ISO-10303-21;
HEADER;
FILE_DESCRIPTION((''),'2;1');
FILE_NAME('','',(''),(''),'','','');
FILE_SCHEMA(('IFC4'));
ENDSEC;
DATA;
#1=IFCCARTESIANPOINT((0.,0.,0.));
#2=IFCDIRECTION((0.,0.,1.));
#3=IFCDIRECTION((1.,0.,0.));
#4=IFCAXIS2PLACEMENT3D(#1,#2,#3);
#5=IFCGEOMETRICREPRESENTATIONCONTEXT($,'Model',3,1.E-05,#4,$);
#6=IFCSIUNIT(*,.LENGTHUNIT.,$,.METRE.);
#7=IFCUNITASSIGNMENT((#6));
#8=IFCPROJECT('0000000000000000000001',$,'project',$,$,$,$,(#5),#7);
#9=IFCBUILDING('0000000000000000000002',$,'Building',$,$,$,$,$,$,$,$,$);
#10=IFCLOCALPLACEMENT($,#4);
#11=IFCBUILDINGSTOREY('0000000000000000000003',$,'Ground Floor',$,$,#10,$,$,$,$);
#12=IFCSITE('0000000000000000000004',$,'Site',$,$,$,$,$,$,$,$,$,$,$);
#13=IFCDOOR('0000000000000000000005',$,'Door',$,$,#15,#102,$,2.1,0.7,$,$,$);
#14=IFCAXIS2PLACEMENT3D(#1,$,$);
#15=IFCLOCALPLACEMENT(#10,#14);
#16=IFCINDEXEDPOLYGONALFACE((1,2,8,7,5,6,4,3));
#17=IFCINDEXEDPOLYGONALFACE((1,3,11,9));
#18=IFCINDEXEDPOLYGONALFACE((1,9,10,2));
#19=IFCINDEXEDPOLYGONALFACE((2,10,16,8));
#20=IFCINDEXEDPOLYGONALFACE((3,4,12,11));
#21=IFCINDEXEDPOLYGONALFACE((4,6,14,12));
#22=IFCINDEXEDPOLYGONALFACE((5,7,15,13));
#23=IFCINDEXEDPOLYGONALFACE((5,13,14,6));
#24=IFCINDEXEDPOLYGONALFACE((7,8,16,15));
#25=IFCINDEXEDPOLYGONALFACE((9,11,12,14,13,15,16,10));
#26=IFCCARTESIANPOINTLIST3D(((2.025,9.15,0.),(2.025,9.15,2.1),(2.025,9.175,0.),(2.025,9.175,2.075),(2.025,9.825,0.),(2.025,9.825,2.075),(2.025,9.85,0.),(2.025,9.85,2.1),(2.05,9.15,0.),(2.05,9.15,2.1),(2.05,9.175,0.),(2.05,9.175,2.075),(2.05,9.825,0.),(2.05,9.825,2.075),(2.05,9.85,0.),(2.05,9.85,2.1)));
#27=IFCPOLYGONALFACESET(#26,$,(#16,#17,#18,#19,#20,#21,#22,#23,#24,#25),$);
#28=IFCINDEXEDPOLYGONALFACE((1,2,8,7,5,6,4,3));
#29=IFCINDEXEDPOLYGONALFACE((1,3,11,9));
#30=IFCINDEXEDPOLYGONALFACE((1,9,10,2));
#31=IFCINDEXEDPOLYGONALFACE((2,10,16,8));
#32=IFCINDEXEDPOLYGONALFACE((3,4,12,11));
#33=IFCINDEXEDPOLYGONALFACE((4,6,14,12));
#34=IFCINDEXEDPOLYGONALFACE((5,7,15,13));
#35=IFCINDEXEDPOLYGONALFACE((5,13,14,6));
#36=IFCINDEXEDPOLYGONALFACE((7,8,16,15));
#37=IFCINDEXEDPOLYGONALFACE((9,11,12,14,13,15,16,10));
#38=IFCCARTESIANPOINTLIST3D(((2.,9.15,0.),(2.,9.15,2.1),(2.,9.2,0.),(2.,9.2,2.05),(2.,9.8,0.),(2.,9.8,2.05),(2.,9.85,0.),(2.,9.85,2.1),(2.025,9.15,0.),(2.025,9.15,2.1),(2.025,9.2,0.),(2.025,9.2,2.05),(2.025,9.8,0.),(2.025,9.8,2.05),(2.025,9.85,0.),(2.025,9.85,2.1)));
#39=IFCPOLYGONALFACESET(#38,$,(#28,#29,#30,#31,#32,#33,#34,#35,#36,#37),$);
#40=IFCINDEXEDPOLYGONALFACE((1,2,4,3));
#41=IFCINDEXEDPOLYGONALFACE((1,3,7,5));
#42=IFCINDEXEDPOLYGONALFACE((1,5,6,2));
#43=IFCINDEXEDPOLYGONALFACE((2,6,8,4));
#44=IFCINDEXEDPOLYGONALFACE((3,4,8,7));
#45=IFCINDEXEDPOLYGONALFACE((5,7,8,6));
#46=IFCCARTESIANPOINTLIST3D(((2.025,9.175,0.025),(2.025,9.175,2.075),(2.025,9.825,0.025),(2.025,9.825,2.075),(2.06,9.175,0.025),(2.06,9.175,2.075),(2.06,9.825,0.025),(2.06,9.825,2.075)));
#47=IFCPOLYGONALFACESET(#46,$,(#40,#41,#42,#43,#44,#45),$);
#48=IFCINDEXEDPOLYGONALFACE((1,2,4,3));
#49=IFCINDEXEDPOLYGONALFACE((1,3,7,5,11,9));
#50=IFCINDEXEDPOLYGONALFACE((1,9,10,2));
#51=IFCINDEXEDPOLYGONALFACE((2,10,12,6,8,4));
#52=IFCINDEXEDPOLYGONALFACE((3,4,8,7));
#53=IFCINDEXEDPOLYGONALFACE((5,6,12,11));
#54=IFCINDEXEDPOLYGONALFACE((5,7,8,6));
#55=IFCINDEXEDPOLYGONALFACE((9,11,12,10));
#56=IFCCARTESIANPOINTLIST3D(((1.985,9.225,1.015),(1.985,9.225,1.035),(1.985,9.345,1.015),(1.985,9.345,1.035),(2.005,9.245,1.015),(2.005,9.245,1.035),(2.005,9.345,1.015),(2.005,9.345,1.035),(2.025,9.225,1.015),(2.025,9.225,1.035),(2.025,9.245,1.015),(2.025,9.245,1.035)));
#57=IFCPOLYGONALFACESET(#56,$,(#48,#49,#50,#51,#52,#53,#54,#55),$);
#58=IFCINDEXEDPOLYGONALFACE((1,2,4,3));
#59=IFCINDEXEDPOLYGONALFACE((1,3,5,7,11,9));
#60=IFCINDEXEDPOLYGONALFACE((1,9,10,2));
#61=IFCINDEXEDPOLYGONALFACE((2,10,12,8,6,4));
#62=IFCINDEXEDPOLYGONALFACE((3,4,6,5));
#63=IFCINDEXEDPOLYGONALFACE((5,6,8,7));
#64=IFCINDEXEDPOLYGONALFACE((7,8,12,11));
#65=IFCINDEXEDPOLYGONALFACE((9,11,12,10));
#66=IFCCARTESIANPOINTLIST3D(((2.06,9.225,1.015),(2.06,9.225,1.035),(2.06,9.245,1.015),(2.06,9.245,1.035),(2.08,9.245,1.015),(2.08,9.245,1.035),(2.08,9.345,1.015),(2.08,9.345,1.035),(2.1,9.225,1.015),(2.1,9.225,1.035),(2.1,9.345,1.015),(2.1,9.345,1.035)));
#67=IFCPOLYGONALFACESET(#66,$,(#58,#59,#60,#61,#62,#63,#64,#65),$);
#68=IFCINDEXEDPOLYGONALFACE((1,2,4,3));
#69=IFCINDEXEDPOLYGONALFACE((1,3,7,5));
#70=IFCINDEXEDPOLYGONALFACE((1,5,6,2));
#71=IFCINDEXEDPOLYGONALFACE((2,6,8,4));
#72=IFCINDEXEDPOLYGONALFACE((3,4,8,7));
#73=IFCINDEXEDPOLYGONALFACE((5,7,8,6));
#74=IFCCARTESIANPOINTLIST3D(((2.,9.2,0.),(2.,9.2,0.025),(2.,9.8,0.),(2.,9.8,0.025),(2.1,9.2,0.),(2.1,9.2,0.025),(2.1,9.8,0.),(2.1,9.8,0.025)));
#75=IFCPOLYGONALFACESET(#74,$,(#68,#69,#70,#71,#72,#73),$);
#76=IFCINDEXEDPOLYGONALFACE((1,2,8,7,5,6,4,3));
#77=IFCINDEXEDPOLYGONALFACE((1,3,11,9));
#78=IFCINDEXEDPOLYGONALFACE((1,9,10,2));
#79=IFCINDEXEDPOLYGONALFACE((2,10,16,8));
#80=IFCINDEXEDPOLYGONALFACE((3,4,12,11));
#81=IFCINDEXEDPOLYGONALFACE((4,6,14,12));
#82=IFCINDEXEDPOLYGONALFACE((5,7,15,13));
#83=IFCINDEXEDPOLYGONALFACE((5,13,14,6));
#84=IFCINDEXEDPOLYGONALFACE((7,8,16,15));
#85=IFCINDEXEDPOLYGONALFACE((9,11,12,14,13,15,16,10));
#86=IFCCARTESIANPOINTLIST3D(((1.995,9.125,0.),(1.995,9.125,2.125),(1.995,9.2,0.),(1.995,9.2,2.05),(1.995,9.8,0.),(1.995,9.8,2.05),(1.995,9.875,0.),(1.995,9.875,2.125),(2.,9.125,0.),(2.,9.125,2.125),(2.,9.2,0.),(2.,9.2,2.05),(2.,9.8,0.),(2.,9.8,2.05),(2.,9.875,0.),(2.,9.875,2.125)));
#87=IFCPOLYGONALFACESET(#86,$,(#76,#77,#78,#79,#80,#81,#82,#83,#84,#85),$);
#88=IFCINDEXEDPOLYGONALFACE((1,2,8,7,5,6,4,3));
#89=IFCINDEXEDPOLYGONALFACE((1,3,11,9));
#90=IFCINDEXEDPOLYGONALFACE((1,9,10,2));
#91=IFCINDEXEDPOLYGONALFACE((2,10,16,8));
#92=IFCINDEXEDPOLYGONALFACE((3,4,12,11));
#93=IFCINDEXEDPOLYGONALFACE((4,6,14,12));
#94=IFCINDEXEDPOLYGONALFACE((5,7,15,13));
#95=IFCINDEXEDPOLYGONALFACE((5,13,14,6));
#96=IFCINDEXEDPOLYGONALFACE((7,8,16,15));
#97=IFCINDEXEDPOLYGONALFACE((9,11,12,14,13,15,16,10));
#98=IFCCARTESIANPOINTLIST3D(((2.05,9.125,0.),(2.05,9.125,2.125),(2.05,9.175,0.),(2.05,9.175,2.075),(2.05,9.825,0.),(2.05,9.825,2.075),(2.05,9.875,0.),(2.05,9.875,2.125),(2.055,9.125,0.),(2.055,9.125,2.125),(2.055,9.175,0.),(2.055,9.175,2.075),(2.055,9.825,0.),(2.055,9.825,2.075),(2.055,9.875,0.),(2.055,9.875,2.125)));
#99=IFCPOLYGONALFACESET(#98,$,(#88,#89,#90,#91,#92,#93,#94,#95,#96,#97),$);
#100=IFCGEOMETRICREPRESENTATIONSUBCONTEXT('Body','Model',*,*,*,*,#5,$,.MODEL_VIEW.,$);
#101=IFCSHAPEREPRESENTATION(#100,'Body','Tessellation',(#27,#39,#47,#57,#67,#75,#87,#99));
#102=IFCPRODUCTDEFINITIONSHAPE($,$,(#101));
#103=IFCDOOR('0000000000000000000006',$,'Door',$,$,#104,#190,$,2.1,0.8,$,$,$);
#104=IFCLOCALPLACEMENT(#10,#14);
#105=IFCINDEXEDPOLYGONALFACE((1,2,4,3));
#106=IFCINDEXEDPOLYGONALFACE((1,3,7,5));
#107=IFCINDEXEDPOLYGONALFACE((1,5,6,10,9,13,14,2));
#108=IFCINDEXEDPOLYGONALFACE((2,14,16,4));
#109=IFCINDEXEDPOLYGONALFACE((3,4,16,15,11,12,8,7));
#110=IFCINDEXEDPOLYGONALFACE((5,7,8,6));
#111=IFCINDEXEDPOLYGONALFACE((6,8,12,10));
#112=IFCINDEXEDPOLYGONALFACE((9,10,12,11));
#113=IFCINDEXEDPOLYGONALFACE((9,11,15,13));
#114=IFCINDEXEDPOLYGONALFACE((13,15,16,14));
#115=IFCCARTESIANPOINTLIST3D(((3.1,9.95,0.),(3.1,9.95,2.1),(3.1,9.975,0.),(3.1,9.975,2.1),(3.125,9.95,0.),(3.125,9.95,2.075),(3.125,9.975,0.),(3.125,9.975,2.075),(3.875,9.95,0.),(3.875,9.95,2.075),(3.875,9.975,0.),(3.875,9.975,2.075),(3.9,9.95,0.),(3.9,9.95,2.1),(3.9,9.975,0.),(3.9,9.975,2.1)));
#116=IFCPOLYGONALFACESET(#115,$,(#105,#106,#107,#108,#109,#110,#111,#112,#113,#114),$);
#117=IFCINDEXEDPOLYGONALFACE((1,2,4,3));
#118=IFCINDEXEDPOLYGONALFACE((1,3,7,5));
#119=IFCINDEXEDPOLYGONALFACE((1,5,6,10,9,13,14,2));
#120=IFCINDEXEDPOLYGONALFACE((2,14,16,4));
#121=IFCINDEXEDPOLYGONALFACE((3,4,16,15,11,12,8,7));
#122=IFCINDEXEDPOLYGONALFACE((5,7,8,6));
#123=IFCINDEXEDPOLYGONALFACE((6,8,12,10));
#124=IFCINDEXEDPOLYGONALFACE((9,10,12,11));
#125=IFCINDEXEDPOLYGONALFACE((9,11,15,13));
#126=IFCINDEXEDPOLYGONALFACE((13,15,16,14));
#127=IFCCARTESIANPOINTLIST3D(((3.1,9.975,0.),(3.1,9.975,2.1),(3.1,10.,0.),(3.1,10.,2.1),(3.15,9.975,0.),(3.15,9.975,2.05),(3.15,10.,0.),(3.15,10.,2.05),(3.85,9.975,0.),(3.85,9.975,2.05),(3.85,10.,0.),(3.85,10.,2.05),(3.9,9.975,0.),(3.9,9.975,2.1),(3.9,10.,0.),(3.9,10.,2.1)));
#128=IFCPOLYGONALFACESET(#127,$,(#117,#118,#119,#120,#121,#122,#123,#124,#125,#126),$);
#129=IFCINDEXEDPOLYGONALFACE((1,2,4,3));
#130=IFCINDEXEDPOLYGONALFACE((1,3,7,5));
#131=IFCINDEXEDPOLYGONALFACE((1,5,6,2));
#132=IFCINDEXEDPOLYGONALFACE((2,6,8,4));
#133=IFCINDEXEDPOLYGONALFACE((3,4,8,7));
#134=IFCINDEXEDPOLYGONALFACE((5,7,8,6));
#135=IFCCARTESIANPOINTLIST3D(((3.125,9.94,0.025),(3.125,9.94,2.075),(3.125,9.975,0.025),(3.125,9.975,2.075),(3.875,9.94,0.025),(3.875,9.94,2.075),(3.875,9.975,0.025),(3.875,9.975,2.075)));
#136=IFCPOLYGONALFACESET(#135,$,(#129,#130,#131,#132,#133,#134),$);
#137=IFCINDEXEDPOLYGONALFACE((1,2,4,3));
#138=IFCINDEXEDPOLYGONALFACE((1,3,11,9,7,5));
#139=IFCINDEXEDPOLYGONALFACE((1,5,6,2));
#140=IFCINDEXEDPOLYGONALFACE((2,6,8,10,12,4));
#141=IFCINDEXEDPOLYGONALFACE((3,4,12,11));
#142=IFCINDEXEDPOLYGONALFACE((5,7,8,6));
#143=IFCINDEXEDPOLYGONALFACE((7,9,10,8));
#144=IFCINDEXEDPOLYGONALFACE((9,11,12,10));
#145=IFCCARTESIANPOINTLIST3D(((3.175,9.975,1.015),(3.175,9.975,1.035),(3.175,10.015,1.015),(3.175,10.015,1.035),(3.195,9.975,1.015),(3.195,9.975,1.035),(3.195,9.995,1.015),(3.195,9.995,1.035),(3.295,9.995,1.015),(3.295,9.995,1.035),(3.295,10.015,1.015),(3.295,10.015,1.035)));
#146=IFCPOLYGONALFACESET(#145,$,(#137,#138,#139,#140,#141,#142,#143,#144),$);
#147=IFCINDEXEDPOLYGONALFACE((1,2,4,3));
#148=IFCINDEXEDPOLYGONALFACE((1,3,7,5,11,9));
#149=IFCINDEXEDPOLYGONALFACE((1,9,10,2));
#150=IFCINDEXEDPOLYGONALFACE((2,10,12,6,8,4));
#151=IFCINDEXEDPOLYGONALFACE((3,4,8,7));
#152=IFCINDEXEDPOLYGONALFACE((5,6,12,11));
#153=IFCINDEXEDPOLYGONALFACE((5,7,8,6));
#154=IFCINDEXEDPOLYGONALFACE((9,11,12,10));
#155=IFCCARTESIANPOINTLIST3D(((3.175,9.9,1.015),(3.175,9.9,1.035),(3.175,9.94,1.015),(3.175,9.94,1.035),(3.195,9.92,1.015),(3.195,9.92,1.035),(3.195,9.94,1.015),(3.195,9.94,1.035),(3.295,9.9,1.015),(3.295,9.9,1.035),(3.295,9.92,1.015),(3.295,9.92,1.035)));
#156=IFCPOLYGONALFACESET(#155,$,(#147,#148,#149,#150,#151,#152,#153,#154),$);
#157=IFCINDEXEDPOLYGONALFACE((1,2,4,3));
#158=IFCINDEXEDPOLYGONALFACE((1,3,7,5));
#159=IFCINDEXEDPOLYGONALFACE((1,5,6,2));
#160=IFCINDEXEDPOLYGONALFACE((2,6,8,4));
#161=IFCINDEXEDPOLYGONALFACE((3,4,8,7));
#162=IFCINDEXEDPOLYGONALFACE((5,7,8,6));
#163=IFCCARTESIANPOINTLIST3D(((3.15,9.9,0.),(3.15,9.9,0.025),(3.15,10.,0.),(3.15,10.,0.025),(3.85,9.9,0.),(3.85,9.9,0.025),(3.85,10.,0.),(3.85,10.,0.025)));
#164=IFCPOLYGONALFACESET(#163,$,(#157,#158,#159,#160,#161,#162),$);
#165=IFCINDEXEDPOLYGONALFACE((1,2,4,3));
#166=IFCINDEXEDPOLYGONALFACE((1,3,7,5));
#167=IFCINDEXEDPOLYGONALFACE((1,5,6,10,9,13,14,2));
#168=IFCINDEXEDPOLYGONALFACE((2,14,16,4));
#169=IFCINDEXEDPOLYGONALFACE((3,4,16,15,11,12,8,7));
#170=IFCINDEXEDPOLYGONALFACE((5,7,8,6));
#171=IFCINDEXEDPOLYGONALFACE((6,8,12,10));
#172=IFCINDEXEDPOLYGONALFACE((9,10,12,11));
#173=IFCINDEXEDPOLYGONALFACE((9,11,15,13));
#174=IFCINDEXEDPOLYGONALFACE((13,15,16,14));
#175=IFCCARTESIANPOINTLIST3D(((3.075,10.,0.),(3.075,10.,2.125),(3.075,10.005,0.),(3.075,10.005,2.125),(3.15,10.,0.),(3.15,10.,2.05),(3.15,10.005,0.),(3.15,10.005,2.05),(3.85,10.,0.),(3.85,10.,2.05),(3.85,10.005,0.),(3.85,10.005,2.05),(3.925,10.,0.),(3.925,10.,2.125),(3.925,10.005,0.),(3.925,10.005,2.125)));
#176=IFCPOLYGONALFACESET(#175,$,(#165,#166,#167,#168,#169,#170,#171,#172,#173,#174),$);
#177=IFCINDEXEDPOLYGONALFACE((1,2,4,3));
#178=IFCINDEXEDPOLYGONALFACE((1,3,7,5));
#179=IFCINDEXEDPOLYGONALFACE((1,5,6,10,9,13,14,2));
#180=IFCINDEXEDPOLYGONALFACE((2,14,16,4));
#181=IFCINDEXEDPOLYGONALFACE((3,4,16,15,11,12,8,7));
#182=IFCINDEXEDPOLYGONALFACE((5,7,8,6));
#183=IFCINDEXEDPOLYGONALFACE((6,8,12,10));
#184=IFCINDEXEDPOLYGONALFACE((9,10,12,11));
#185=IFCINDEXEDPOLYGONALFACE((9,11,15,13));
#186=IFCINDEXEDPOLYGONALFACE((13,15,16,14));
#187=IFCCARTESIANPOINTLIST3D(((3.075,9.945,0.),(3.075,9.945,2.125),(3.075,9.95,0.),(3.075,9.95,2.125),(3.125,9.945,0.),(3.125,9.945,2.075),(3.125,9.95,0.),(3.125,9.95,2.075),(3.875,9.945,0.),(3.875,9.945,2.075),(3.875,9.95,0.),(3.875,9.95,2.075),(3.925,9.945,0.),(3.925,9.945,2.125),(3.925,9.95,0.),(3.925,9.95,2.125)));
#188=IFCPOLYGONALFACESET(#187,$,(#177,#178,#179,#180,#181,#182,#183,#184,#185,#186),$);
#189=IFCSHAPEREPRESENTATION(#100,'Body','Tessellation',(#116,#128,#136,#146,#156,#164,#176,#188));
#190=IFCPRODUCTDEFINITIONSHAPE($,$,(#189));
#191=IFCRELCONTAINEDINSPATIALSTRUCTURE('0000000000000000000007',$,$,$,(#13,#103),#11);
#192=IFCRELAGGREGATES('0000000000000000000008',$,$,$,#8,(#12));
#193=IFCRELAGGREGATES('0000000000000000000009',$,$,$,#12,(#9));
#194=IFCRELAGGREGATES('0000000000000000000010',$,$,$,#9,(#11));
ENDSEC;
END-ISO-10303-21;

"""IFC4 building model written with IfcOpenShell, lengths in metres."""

from ifc_helpers import new_model, si_unit, frame, origin_with_axes, place, context, subcontext, project, spatial, line, indexed_curve, outline, extrude, element, save


model = new_model("IFC4")

# Units and contexts
model_context = context("Model", 3, precision=1e-05, world=origin_with_axes())
body_context = subcontext(model_context, "Body", "Model", "MODEL_VIEW")
ifc_project = project(units=[si_unit("LENGTHUNIT", "METRE")], contexts=[model_context])

# Site, building, storey
site = spatial("IfcSite", under=ifc_project, Name="Site")
building = spatial("IfcBuilding", under=site, Name="Building")
storey_placement = place(None, origin_with_axes())
storey = spatial("IfcBuildingStorey", under=building, at=storey_placement, Name="Ground Floor")

# Doors
door_1_placement = place(storey_placement, frame((2.0, 9.85, 0.0), z_axis=(0.0, 0.0, 1.0), x_axis=(0.0, -1.0, 0.0)))
element("IfcDoor", 1, at=door_1_placement, inside=storey, Name="Door", OverallHeight=2.1, OverallWidth=0.7, context=body_context, shape_type="SweptSolid", body=[
    extrude(outline(indexed_curve([(0.0, 0.0), (0.0, 2.1), (0.7, 2.1), (0.7, 0.0), (0.675, 0.0), (0.675, 2.075), (0.025, 2.075), (0.025, 0.0)], segments=[line(1, 2, 3, 4, 5, 6, 7, 8, 1)])), frame((0.0, 0.025, 0.0), z_axis=(0.0, -1.0, 0.0), x_axis=(1.0, 0.0, 0.0)), (0.0, 0.0, -1.0), 0.025),
    extrude(outline(indexed_curve([(0.0, 0.0), (0.0, 2.1), (0.7, 2.1), (0.7, 0.0), (0.65, 0.0), (0.65, 2.05), (0.05, 2.05), (0.05, 0.0)], segments=[line(1, 2, 3, 4, 5, 6, 7, 8, 1)])), frame((0.0, 0.0, 0.0), z_axis=(0.0, -1.0, 0.0), x_axis=(1.0, 0.0, 0.0)), (0.0, 0.0, -1.0), 0.025),
    extrude(outline(indexed_curve([(0.0, 0.0), (0.65, 0.0), (0.65, 0.035), (0.0, 0.035)], segments=[line(1, 2, 3, 4, 1)])), frame((0.025, 0.025, 0.025), z_axis=(0.0, 0.0, 1.0), x_axis=(1.0, 0.0, 0.0)), (0.0, 0.0, 1.0), 2.05),
    extrude(outline(indexed_curve([(0.0, 0.0), (0.0, -0.04), (-0.12, -0.04), (-0.12, -0.02), (-0.02, -0.02), (-0.02, 0.0)], segments=[line(1, 2, 3, 4, 5, 6, 1)])), frame((0.625, 0.025, 1.015), z_axis=(0.0, 0.0, 1.0), x_axis=(1.0, 0.0, 0.0)), (0.0, 0.0, 1.0), 0.02),
    extrude(outline(indexed_curve([(0.0, 0.0), (0.0, 0.04), (-0.12, 0.04), (-0.12, 0.02), (-0.02, 0.02), (-0.02, 0.0)], segments=[line(1, 2, 3, 4, 5, 6, 1)])), frame((0.625, 0.06, 1.015), z_axis=(0.0, 0.0, 1.0), x_axis=(1.0, 0.0, 0.0)), (0.0, 0.0, 1.0), 0.02),
    extrude(outline(indexed_curve([(0.0, 0.0), (0.6, 0.0), (0.6, 0.1), (0.0, 0.1)], segments=[line(1, 2, 3, 4, 1)])), frame((0.05, 0.0, 0.0), z_axis=(0.0, 0.0, 1.0), x_axis=(1.0, 0.0, 0.0)), (0.0, 0.0, 1.0), 0.025),
    extrude(outline(indexed_curve([(0.0, 0.0), (0.0, 2.125), (0.75, 2.125), (0.75, 0.0), (0.675, 0.0), (0.675, 2.05), (0.075, 2.05), (0.075, 0.0)], segments=[line(1, 2, 3, 4, 5, 6, 7, 8, 1)])), frame((-0.025, -0.005, 0.0), z_axis=(0.0, -1.0, 0.0), x_axis=(1.0, 0.0, 0.0)), (0.0, 0.0, -1.0), 0.005),
    extrude(outline(indexed_curve([(0.0, 0.0), (0.0, 2.125), (0.75, 2.125), (0.75, 0.0), (0.7, 0.0), (0.7, 2.075), (0.05, 2.075), (0.05, 0.0)], segments=[line(1, 2, 3, 4, 5, 6, 7, 8, 1)])), frame((-0.025, 0.05, 0.0), z_axis=(0.0, -1.0, 0.0), x_axis=(1.0, 0.0, 0.0)), (0.0, 0.0, -1.0), 0.005),
])
door_2_placement = place(storey_placement, frame((3.9, 10.0, 0.0), z_axis=(0.0, 0.0, 1.0), x_axis=(-1.0, 0.0, 0.0)))
element("IfcDoor", 2, at=door_2_placement, inside=storey, Name="Door", OverallHeight=2.1, OverallWidth=0.8, context=body_context, shape_type="SweptSolid", body=[
    extrude(outline(indexed_curve([(0.0, 0.0), (0.0, 2.1), (0.8, 2.1), (0.8, 0.0), (0.775, 0.0), (0.775, 2.075), (0.025, 2.075), (0.025, 0.0)], segments=[line(1, 2, 3, 4, 5, 6, 7, 8, 1)])), frame((0.0, 0.025, 0.0), z_axis=(0.0, -1.0, 0.0), x_axis=(1.0, 0.0, 0.0)), (0.0, 0.0, -1.0), 0.025),
    extrude(outline(indexed_curve([(0.0, 0.0), (0.0, 2.1), (0.8, 2.1), (0.8, 0.0), (0.75, 0.0), (0.75, 2.05), (0.05, 2.05), (0.05, 0.0)], segments=[line(1, 2, 3, 4, 5, 6, 7, 8, 1)])), frame((0.0, 0.0, 0.0), z_axis=(0.0, -1.0, 0.0), x_axis=(1.0, 0.0, 0.0)), (0.0, 0.0, -1.0), 0.025),
    extrude(outline(indexed_curve([(0.0, 0.0), (0.75, 0.0), (0.75, 0.035), (0.0, 0.035)], segments=[line(1, 2, 3, 4, 1)])), frame((0.025, 0.025, 0.025), z_axis=(0.0, 0.0, 1.0), x_axis=(1.0, 0.0, 0.0)), (0.0, 0.0, 1.0), 2.05),
    extrude(outline(indexed_curve([(0.0, 0.0), (0.0, -0.04), (-0.12, -0.04), (-0.12, -0.02), (-0.02, -0.02), (-0.02, 0.0)], segments=[line(1, 2, 3, 4, 5, 6, 1)])), frame((0.725, 0.025, 1.015), z_axis=(0.0, 0.0, 1.0), x_axis=(1.0, 0.0, 0.0)), (0.0, 0.0, 1.0), 0.02),
    extrude(outline(indexed_curve([(0.0, 0.0), (0.0, 0.04), (-0.12, 0.04), (-0.12, 0.02), (-0.02, 0.02), (-0.02, 0.0)], segments=[line(1, 2, 3, 4, 5, 6, 1)])), frame((0.725, 0.06, 1.015), z_axis=(0.0, 0.0, 1.0), x_axis=(1.0, 0.0, 0.0)), (0.0, 0.0, 1.0), 0.02),
    extrude(outline(indexed_curve([(0.0, 0.0), (0.7, 0.0), (0.7, 0.1), (0.0, 0.1)], segments=[line(1, 2, 3, 4, 1)])), frame((0.05, 0.0, 0.0), z_axis=(0.0, 0.0, 1.0), x_axis=(1.0, 0.0, 0.0)), (0.0, 0.0, 1.0), 0.025),
    extrude(outline(indexed_curve([(0.0, 0.0), (0.0, 2.125), (0.85, 2.125), (0.85, 0.0), (0.775, 0.0), (0.775, 2.05), (0.075, 2.05), (0.075, 0.0)], segments=[line(1, 2, 3, 4, 5, 6, 7, 8, 1)])), frame((-0.025, -0.005, 0.0), z_axis=(0.0, -1.0, 0.0), x_axis=(1.0, 0.0, 0.0)), (0.0, 0.0, -1.0), 0.005),
    extrude(outline(indexed_curve([(0.0, 0.0), (0.0, 2.125), (0.85, 2.125), (0.85, 0.0), (0.8, 0.0), (0.8, 2.075), (0.05, 2.075), (0.05, 0.0)], segments=[line(1, 2, 3, 4, 5, 6, 7, 8, 1)])), frame((-0.025, 0.05, 0.0), z_axis=(0.0, -1.0, 0.0), x_axis=(1.0, 0.0, 0.0)), (0.0, 0.0, -1.0), 0.005),
])

save(model, "model.ifc")
